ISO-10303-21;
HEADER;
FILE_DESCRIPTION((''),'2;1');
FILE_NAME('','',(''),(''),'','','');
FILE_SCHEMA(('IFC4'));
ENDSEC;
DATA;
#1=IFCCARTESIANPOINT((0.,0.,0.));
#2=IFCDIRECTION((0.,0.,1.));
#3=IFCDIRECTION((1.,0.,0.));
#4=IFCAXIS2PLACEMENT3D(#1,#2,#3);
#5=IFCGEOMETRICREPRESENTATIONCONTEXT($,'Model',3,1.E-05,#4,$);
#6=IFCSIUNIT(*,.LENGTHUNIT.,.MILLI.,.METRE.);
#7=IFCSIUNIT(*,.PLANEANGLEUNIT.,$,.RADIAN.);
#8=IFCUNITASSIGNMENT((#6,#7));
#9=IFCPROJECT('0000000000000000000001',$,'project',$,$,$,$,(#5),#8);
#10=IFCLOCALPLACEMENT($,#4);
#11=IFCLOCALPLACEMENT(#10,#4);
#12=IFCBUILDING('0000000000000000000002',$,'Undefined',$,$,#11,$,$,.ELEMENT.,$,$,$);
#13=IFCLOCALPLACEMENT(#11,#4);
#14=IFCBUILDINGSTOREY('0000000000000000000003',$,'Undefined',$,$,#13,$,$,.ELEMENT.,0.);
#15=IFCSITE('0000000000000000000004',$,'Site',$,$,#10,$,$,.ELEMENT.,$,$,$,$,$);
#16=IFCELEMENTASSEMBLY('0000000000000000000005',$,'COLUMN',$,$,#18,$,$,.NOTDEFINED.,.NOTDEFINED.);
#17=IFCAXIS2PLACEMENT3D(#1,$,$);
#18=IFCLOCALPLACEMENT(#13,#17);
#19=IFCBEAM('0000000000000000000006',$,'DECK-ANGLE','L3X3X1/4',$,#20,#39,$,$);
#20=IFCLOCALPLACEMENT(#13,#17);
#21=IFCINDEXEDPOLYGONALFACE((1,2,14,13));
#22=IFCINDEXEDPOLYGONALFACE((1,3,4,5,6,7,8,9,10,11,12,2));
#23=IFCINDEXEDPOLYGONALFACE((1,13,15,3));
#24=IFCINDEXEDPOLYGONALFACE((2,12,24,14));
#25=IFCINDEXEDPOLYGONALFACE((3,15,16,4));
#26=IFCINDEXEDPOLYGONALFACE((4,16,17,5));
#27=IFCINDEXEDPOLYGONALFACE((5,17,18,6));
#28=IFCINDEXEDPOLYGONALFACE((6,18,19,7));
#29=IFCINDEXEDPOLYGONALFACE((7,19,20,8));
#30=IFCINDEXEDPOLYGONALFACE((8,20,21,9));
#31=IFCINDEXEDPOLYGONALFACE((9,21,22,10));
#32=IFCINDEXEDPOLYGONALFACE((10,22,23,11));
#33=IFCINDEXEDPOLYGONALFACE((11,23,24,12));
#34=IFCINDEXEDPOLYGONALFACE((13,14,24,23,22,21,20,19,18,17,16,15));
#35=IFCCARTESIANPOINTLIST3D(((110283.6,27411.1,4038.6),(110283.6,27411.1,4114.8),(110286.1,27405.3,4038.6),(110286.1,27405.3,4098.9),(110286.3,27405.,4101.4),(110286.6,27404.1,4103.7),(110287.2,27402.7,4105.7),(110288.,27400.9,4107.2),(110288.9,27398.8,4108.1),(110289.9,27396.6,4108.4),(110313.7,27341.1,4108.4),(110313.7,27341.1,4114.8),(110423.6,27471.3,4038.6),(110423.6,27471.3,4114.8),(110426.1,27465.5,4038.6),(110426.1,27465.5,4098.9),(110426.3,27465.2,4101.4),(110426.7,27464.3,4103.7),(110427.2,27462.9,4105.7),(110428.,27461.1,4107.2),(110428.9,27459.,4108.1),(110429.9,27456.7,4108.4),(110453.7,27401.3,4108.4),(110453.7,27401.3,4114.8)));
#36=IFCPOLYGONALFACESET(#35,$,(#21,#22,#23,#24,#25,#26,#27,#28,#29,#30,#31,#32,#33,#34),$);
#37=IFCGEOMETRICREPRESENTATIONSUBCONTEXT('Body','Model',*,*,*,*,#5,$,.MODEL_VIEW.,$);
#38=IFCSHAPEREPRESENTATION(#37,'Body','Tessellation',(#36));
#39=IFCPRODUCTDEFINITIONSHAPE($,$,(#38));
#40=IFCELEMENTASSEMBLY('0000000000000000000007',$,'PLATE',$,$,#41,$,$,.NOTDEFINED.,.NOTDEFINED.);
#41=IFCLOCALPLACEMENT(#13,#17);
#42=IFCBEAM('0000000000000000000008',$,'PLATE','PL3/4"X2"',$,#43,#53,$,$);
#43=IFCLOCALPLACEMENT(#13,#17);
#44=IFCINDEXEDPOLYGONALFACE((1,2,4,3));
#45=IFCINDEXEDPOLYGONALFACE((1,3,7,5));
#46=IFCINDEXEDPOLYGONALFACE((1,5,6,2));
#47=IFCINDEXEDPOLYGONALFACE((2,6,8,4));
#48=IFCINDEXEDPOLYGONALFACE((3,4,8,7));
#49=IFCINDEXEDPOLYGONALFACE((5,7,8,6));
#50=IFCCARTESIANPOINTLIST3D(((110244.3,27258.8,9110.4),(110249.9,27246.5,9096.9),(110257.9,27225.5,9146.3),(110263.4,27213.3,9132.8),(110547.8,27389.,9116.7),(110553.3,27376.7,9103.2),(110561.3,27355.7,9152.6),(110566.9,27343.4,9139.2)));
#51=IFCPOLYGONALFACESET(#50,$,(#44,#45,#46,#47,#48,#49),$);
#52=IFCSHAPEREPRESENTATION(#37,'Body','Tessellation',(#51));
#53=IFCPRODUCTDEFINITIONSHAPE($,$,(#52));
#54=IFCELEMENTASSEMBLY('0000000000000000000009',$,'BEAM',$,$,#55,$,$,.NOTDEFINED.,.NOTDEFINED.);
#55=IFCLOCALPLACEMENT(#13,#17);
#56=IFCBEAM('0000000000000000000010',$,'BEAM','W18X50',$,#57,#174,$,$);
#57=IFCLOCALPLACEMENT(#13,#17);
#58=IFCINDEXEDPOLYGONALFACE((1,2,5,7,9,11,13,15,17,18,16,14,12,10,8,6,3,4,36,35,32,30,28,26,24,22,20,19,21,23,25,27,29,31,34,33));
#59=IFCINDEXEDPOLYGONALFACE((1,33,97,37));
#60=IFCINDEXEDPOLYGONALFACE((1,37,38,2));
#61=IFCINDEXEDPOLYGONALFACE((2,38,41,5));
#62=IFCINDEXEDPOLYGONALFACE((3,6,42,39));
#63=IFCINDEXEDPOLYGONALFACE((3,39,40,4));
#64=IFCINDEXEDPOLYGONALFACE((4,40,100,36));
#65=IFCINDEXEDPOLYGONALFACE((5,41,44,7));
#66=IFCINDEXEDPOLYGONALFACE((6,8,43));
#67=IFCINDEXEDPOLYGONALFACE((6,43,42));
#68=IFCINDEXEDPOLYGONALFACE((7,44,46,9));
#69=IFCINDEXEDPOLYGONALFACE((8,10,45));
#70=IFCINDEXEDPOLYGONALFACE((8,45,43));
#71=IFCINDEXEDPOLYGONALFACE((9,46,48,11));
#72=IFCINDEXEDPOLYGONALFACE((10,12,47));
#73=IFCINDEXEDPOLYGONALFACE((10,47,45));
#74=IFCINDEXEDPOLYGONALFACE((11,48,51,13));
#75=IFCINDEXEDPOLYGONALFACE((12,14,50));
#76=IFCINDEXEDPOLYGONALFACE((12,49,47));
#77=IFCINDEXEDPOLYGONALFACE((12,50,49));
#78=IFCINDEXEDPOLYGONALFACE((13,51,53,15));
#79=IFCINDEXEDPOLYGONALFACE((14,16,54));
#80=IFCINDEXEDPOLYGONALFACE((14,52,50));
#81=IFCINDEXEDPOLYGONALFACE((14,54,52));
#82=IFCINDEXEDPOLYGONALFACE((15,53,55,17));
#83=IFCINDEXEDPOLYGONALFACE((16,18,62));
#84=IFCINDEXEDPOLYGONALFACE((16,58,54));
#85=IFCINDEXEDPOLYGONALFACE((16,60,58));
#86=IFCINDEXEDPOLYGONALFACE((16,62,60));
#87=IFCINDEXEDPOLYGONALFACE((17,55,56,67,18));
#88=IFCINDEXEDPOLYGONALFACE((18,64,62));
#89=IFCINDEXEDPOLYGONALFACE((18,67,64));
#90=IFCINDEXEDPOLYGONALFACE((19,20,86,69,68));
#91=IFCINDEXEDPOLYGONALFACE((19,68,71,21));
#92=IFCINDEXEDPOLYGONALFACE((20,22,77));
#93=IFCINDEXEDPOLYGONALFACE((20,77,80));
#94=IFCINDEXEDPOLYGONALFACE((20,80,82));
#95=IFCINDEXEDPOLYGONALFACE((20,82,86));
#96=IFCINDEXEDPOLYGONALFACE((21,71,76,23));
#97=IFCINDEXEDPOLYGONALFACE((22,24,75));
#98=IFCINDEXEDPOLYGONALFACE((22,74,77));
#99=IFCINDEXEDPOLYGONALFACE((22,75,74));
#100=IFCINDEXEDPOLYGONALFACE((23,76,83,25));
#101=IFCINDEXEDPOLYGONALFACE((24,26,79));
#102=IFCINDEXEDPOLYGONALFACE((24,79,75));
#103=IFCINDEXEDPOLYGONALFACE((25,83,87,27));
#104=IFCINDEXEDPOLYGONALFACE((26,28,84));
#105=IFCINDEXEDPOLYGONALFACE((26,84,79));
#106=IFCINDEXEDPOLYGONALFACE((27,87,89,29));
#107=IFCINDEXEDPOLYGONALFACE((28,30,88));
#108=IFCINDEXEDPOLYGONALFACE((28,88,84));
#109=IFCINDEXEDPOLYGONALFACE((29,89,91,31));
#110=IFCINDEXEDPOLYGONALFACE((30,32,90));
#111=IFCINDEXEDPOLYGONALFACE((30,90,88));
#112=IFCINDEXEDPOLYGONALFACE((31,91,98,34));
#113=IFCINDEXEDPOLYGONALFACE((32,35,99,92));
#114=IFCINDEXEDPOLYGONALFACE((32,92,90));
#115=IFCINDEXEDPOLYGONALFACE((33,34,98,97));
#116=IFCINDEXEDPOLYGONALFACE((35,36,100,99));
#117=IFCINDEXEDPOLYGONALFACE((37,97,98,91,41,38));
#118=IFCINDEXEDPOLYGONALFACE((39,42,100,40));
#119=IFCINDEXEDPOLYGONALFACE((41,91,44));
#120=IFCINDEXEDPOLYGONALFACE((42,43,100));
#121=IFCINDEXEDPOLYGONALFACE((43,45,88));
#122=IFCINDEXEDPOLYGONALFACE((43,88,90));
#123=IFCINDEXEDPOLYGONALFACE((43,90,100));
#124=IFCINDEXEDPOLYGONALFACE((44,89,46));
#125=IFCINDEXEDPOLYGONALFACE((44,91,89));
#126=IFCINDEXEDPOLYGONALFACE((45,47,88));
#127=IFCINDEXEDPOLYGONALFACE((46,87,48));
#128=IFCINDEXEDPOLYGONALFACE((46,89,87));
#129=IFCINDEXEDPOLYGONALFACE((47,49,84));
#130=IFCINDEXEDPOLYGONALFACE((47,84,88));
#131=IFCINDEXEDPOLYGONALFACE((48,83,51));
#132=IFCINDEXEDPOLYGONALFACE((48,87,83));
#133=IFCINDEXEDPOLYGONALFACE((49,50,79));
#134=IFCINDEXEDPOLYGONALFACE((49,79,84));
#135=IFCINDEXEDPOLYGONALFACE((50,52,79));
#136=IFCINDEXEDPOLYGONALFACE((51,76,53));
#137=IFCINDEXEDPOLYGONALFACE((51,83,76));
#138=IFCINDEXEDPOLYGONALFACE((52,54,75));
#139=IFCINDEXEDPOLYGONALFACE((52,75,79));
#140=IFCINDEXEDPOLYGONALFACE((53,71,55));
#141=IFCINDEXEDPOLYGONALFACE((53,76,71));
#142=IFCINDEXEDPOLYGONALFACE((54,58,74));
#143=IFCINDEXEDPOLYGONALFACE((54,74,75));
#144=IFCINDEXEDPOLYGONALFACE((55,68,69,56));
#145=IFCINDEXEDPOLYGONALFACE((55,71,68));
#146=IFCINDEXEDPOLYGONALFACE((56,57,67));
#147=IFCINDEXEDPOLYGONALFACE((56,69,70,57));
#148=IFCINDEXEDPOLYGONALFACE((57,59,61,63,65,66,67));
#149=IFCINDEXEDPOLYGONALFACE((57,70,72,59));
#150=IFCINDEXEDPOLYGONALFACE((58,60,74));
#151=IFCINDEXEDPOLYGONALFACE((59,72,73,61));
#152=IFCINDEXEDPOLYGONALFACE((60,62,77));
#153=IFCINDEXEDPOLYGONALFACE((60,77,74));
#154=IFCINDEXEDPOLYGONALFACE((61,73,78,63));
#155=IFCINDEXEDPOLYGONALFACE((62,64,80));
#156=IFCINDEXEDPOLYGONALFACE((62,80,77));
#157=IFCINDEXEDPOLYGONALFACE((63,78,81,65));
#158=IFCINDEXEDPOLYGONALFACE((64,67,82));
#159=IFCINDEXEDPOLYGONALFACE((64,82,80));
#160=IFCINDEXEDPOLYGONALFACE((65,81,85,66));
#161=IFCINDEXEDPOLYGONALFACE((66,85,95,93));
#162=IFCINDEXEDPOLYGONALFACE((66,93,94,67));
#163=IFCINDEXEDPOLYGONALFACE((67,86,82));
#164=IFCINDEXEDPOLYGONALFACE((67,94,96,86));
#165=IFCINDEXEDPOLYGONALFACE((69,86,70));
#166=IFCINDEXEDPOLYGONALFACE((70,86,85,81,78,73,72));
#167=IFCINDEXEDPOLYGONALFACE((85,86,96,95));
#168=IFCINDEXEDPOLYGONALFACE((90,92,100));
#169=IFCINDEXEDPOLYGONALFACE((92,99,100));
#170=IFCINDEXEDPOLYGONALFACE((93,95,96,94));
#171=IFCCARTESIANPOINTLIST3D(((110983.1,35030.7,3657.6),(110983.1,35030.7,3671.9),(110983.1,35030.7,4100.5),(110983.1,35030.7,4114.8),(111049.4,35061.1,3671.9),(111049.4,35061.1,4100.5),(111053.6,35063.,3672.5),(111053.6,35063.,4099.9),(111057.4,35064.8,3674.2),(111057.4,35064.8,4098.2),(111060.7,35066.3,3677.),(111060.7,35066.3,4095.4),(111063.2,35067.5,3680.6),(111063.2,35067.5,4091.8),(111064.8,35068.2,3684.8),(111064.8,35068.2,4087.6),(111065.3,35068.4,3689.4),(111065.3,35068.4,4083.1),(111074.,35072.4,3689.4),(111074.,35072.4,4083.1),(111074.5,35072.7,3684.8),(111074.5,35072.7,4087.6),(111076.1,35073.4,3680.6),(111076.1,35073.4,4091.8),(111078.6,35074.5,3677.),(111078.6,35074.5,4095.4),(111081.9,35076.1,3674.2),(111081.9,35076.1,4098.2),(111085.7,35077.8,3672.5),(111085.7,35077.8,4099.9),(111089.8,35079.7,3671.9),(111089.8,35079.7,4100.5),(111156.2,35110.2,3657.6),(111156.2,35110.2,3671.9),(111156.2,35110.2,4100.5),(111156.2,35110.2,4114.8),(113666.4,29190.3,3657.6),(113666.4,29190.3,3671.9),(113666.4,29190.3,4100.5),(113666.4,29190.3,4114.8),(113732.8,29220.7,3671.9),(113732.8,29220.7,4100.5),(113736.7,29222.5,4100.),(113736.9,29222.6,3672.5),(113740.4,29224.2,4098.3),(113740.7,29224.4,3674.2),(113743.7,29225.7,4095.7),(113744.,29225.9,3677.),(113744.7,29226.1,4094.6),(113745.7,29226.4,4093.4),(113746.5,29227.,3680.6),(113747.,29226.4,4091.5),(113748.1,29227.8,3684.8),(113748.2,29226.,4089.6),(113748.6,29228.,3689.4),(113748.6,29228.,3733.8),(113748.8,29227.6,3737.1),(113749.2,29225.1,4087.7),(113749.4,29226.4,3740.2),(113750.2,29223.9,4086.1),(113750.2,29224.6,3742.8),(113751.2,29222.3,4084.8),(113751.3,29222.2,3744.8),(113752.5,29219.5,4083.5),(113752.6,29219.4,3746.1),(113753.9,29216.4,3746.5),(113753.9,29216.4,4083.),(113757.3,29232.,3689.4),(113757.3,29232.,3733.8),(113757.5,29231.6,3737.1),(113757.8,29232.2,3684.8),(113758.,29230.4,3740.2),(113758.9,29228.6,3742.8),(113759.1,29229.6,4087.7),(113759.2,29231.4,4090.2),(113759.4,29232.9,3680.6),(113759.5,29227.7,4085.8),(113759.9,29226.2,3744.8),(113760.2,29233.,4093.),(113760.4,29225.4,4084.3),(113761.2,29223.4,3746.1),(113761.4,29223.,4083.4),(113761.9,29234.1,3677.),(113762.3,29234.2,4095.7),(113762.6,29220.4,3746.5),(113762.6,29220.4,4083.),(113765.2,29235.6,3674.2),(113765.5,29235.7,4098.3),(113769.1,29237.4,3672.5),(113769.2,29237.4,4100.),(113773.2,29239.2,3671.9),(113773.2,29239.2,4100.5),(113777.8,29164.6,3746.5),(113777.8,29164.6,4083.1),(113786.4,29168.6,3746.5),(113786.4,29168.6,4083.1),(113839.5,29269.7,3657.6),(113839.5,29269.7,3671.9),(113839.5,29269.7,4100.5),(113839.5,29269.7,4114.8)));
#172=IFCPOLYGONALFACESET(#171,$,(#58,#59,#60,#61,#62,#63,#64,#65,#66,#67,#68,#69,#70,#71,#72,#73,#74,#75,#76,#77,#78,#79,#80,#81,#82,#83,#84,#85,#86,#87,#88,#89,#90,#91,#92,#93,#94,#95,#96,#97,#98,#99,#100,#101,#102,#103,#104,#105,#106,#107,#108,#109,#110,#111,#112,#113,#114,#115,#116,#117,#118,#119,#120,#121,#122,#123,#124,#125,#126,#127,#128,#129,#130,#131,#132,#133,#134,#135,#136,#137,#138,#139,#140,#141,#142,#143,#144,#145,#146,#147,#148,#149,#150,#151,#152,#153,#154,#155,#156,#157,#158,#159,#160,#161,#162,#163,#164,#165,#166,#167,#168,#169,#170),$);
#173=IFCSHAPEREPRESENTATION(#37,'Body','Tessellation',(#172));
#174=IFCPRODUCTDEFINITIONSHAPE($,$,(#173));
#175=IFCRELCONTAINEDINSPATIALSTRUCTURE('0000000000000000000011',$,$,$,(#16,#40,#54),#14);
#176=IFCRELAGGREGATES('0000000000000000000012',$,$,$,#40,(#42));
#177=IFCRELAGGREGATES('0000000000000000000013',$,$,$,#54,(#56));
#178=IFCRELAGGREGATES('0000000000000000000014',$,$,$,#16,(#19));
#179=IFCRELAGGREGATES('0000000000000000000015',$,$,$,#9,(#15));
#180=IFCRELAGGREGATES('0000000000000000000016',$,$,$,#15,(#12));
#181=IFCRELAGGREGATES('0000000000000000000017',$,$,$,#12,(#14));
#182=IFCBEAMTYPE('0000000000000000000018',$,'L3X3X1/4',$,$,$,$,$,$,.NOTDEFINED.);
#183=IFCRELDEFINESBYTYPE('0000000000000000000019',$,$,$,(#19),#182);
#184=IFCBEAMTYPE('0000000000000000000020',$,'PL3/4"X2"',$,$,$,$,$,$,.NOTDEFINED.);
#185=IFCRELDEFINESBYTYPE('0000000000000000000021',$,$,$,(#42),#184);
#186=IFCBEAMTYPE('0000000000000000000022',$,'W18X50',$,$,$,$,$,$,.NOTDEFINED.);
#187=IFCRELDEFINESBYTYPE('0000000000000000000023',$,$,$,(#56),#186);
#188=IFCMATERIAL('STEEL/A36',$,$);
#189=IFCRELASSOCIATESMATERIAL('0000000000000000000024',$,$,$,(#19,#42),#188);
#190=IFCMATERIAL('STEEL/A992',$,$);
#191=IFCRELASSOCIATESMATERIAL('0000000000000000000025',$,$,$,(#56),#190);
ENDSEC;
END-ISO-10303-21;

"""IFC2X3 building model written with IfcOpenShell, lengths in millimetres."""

from ifc_helpers import new_model, si_unit, frame, frame_2d, origin_with_axes, origin_2d_with_axis, place, context, subcontext, project, spatial, polyline, circle_curve, parameter, trimmed, segment, composite_curve, rectangle, i_section, l_section, outline, extrude, boolean, halfspace, material, type_object, element, aggregate, save


model = new_model("IFC2X3")

# Units and contexts
model_context = context("Model", 3, precision=1e-05, world=origin_with_axes())
body_context = subcontext(model_context, "Body", "Model", "MODEL_VIEW")
ifc_project = project(units=[si_unit("LENGTHUNIT", "METRE", prefix="MILLI"), si_unit("PLANEANGLEUNIT", "RADIAN")], contexts=[model_context])

# Site, building, storey
site_placement = place(None, origin_with_axes())
site = spatial("IfcSite", under=ifc_project, at=site_placement, Name="Site", CompositionType="ELEMENT")
building_placement = place(site_placement, origin_with_axes())
building = spatial("IfcBuilding", under=site, at=building_placement, Name="Undefined", CompositionType="ELEMENT")
storey_placement = place(building_placement, origin_with_axes())
storey = spatial("IfcBuildingStorey", under=building, at=storey_placement, Name="Undefined", CompositionType="ELEMENT", Elevation=0.0)

# Element assembly, beam
assembly_1_placement = place(storey_placement, origin_with_axes())
assembly_1 = element("IfcElementAssembly", 1, at=assembly_1_placement, inside=storey, Name="COLUMN", AssemblyPlace="NOTDEFINED", PredefinedType="NOTDEFINED")
ifc_material_1 = material(Name="STEEL/A36")
beam_type_1 = type_object("IfcBeamType", Name="L3X3X1/4", PredefinedType="NOTDEFINED")
beam_1_placement = place(assembly_1_placement, frame((110438.7, 27436.3, 4076.7), z_axis=(0.0, 0.0, -1.0), x_axis=(-0.918753, -0.394832, 0.0)))
beam_1 = element("IfcBeam", 2, at=beam_1_placement, type_object=beam_type_1, material=ifc_material_1, Name="DECK-ANGLE", Description="L3X3X1/4", context=body_context, shape_type="SweptSolid", body=[
    extrude(l_section(Depth=76.2, Width=76.2, Thickness=6.3, FilletRadius=9.5, at=origin_2d_with_axis()), frame((152.4, 0.0, 0.0), z_axis=(-1.0, 0.0, 0.0), x_axis=(0.0, -1.0, 0.0)), (0.0, 0.0, 1.0), 152.4),
])

# Element assemblies, beams
assembly_2_placement = place(storey_placement, origin_with_axes())
assembly_2 = element("IfcElementAssembly", 3, at=assembly_2_placement, inside=storey, Name="PLATE", AssemblyPlace="NOTDEFINED", PredefinedType="NOTDEFINED")
beam_type_2 = type_object("IfcBeamType", Name="PL3/4\"X2\"", PredefinedType="NOTDEFINED")
beam_2_placement = place(assembly_2_placement, frame((110557.3, 27366.2, 9127.9), z_axis=(0.266309, -0.655183, 0.706976), x_axis=(-0.918817, -0.394214, -0.019227)))
beam_2 = element("IfcBeam", 4, at=beam_2_placement, type_object=beam_type_2, material=ifc_material_1, Name="PLATE", Description="PL3/4\"X2\"", context=body_context, shape_type="SweptSolid", body=[
    extrude(rectangle(XDim=19.1, YDim=50.8, at=origin_2d_with_axis()), frame((330.3, 0.0, 0.0), z_axis=(-1.0, 0.0, 0.0), x_axis=(0.0, -1.0, 0.0)), (0.0, 0.0, 1.0), 330.3),
])
aggregate(assembly_2, [beam_2])
assembly_3_placement = place(storey_placement, origin_with_axes())
assembly_3 = element("IfcElementAssembly", 5, at=assembly_3_placement, inside=storey, Name="BEAM", AssemblyPlace="NOTDEFINED", PredefinedType="NOTDEFINED")
ifc_material_2 = material(Name="STEEL/A992")
beam_type_3 = type_object("IfcBeamType", Name="W18X50", PredefinedType="NOTDEFINED")
beam_3_placement = place(assembly_3_placement, frame((113788.8, 29152.1, 3886.2), z_axis=(0.0, 0.0, 1.0), x_axis=(-0.417484, 0.908684, 0.0)))
beam_3 = element("IfcBeam", 6, at=beam_3_placement, type_object=beam_type_3, material=ifc_material_2, Name="BEAM", Description="W18X50", context=body_context, shape_type="CSG", body=[
    boolean("DIFFERENCE", boolean("DIFFERENCE", boolean("DIFFERENCE", boolean("DIFFERENCE", extrude(i_section(OverallWidth=190.5, OverallDepth=457.2, WebThickness=9.5, FlangeThickness=14.3, FilletRadius=17.5, at=origin_2d_with_axis()), frame((6612.1, 0.0, 0.0), z_axis=(-1.0, 0.0, 0.0), x_axis=(0.0, -1.0, 0.0)), (0.0, 0.0, 1.0), 6695.2), extrude(outline(composite_curve([segment(polyline([(0.0, 0.0), (67.1, 0.0)]), True, "CONTINUOUS"), segment(trimmed(circle_curve(frame_2d((67.1, 12.7), x_axis=(0.0, -1.0)), 12.7), [parameter(0.0)], [parameter(1.570796)], True, "PARAMETER"), True, "CONTINUOUS"), segment(polyline([(79.8, 12.7), (79.8, 41.8), (-0.1, 41.8), (0.0, 0.0)]), True, "CONTINUOUS")], self_intersect=True)), frame((6.0, 105.3, 196.9), z_axis=(-0.000781, -1.0, 0.0), x_axis=(1.0, -0.000781, 0.0)), (0.0, 0.0, 1.0), 210.6)), extrude(outline(composite_curve([segment(polyline([(0.0, 0.0), (67.1, 0.0)]), True, "CONTINUOUS"), segment(trimmed(circle_curve(frame_2d((67.1, 12.7), x_axis=(0.0, -1.0)), 12.7), [parameter(0.0)], [parameter(1.570796)], True, "PARAMETER"), True, "CONTINUOUS"), segment(polyline([(79.8, 12.7), (79.8, 98.9), (-0.1, 98.9), (0.0, 0.0)]), True, "CONTINUOUS")], self_intersect=True)), frame((5.8, -105.3, -139.7), z_axis=(0.000781, 1.0, 0.0), x_axis=(1.0, -0.000781, 0.0)), (0.0, 0.0, 1.0), 210.6)), halfspace(frame((6513.1, 0.0, -1000.0), z_axis=(-1.0, 0.0, 0.0), x_axis=(0.0, 1.0, 0.0)), True)), halfspace(frame((16.0, 0.0, 328.6), z_axis=(-1.0, 0.000781, 0.0), x_axis=(-0.000781, -1.0, 0.0)), False)),
])
aggregate(assembly_3, [beam_3])

aggregate(assembly_1, [beam_1])

save(model, "model.ifc")
